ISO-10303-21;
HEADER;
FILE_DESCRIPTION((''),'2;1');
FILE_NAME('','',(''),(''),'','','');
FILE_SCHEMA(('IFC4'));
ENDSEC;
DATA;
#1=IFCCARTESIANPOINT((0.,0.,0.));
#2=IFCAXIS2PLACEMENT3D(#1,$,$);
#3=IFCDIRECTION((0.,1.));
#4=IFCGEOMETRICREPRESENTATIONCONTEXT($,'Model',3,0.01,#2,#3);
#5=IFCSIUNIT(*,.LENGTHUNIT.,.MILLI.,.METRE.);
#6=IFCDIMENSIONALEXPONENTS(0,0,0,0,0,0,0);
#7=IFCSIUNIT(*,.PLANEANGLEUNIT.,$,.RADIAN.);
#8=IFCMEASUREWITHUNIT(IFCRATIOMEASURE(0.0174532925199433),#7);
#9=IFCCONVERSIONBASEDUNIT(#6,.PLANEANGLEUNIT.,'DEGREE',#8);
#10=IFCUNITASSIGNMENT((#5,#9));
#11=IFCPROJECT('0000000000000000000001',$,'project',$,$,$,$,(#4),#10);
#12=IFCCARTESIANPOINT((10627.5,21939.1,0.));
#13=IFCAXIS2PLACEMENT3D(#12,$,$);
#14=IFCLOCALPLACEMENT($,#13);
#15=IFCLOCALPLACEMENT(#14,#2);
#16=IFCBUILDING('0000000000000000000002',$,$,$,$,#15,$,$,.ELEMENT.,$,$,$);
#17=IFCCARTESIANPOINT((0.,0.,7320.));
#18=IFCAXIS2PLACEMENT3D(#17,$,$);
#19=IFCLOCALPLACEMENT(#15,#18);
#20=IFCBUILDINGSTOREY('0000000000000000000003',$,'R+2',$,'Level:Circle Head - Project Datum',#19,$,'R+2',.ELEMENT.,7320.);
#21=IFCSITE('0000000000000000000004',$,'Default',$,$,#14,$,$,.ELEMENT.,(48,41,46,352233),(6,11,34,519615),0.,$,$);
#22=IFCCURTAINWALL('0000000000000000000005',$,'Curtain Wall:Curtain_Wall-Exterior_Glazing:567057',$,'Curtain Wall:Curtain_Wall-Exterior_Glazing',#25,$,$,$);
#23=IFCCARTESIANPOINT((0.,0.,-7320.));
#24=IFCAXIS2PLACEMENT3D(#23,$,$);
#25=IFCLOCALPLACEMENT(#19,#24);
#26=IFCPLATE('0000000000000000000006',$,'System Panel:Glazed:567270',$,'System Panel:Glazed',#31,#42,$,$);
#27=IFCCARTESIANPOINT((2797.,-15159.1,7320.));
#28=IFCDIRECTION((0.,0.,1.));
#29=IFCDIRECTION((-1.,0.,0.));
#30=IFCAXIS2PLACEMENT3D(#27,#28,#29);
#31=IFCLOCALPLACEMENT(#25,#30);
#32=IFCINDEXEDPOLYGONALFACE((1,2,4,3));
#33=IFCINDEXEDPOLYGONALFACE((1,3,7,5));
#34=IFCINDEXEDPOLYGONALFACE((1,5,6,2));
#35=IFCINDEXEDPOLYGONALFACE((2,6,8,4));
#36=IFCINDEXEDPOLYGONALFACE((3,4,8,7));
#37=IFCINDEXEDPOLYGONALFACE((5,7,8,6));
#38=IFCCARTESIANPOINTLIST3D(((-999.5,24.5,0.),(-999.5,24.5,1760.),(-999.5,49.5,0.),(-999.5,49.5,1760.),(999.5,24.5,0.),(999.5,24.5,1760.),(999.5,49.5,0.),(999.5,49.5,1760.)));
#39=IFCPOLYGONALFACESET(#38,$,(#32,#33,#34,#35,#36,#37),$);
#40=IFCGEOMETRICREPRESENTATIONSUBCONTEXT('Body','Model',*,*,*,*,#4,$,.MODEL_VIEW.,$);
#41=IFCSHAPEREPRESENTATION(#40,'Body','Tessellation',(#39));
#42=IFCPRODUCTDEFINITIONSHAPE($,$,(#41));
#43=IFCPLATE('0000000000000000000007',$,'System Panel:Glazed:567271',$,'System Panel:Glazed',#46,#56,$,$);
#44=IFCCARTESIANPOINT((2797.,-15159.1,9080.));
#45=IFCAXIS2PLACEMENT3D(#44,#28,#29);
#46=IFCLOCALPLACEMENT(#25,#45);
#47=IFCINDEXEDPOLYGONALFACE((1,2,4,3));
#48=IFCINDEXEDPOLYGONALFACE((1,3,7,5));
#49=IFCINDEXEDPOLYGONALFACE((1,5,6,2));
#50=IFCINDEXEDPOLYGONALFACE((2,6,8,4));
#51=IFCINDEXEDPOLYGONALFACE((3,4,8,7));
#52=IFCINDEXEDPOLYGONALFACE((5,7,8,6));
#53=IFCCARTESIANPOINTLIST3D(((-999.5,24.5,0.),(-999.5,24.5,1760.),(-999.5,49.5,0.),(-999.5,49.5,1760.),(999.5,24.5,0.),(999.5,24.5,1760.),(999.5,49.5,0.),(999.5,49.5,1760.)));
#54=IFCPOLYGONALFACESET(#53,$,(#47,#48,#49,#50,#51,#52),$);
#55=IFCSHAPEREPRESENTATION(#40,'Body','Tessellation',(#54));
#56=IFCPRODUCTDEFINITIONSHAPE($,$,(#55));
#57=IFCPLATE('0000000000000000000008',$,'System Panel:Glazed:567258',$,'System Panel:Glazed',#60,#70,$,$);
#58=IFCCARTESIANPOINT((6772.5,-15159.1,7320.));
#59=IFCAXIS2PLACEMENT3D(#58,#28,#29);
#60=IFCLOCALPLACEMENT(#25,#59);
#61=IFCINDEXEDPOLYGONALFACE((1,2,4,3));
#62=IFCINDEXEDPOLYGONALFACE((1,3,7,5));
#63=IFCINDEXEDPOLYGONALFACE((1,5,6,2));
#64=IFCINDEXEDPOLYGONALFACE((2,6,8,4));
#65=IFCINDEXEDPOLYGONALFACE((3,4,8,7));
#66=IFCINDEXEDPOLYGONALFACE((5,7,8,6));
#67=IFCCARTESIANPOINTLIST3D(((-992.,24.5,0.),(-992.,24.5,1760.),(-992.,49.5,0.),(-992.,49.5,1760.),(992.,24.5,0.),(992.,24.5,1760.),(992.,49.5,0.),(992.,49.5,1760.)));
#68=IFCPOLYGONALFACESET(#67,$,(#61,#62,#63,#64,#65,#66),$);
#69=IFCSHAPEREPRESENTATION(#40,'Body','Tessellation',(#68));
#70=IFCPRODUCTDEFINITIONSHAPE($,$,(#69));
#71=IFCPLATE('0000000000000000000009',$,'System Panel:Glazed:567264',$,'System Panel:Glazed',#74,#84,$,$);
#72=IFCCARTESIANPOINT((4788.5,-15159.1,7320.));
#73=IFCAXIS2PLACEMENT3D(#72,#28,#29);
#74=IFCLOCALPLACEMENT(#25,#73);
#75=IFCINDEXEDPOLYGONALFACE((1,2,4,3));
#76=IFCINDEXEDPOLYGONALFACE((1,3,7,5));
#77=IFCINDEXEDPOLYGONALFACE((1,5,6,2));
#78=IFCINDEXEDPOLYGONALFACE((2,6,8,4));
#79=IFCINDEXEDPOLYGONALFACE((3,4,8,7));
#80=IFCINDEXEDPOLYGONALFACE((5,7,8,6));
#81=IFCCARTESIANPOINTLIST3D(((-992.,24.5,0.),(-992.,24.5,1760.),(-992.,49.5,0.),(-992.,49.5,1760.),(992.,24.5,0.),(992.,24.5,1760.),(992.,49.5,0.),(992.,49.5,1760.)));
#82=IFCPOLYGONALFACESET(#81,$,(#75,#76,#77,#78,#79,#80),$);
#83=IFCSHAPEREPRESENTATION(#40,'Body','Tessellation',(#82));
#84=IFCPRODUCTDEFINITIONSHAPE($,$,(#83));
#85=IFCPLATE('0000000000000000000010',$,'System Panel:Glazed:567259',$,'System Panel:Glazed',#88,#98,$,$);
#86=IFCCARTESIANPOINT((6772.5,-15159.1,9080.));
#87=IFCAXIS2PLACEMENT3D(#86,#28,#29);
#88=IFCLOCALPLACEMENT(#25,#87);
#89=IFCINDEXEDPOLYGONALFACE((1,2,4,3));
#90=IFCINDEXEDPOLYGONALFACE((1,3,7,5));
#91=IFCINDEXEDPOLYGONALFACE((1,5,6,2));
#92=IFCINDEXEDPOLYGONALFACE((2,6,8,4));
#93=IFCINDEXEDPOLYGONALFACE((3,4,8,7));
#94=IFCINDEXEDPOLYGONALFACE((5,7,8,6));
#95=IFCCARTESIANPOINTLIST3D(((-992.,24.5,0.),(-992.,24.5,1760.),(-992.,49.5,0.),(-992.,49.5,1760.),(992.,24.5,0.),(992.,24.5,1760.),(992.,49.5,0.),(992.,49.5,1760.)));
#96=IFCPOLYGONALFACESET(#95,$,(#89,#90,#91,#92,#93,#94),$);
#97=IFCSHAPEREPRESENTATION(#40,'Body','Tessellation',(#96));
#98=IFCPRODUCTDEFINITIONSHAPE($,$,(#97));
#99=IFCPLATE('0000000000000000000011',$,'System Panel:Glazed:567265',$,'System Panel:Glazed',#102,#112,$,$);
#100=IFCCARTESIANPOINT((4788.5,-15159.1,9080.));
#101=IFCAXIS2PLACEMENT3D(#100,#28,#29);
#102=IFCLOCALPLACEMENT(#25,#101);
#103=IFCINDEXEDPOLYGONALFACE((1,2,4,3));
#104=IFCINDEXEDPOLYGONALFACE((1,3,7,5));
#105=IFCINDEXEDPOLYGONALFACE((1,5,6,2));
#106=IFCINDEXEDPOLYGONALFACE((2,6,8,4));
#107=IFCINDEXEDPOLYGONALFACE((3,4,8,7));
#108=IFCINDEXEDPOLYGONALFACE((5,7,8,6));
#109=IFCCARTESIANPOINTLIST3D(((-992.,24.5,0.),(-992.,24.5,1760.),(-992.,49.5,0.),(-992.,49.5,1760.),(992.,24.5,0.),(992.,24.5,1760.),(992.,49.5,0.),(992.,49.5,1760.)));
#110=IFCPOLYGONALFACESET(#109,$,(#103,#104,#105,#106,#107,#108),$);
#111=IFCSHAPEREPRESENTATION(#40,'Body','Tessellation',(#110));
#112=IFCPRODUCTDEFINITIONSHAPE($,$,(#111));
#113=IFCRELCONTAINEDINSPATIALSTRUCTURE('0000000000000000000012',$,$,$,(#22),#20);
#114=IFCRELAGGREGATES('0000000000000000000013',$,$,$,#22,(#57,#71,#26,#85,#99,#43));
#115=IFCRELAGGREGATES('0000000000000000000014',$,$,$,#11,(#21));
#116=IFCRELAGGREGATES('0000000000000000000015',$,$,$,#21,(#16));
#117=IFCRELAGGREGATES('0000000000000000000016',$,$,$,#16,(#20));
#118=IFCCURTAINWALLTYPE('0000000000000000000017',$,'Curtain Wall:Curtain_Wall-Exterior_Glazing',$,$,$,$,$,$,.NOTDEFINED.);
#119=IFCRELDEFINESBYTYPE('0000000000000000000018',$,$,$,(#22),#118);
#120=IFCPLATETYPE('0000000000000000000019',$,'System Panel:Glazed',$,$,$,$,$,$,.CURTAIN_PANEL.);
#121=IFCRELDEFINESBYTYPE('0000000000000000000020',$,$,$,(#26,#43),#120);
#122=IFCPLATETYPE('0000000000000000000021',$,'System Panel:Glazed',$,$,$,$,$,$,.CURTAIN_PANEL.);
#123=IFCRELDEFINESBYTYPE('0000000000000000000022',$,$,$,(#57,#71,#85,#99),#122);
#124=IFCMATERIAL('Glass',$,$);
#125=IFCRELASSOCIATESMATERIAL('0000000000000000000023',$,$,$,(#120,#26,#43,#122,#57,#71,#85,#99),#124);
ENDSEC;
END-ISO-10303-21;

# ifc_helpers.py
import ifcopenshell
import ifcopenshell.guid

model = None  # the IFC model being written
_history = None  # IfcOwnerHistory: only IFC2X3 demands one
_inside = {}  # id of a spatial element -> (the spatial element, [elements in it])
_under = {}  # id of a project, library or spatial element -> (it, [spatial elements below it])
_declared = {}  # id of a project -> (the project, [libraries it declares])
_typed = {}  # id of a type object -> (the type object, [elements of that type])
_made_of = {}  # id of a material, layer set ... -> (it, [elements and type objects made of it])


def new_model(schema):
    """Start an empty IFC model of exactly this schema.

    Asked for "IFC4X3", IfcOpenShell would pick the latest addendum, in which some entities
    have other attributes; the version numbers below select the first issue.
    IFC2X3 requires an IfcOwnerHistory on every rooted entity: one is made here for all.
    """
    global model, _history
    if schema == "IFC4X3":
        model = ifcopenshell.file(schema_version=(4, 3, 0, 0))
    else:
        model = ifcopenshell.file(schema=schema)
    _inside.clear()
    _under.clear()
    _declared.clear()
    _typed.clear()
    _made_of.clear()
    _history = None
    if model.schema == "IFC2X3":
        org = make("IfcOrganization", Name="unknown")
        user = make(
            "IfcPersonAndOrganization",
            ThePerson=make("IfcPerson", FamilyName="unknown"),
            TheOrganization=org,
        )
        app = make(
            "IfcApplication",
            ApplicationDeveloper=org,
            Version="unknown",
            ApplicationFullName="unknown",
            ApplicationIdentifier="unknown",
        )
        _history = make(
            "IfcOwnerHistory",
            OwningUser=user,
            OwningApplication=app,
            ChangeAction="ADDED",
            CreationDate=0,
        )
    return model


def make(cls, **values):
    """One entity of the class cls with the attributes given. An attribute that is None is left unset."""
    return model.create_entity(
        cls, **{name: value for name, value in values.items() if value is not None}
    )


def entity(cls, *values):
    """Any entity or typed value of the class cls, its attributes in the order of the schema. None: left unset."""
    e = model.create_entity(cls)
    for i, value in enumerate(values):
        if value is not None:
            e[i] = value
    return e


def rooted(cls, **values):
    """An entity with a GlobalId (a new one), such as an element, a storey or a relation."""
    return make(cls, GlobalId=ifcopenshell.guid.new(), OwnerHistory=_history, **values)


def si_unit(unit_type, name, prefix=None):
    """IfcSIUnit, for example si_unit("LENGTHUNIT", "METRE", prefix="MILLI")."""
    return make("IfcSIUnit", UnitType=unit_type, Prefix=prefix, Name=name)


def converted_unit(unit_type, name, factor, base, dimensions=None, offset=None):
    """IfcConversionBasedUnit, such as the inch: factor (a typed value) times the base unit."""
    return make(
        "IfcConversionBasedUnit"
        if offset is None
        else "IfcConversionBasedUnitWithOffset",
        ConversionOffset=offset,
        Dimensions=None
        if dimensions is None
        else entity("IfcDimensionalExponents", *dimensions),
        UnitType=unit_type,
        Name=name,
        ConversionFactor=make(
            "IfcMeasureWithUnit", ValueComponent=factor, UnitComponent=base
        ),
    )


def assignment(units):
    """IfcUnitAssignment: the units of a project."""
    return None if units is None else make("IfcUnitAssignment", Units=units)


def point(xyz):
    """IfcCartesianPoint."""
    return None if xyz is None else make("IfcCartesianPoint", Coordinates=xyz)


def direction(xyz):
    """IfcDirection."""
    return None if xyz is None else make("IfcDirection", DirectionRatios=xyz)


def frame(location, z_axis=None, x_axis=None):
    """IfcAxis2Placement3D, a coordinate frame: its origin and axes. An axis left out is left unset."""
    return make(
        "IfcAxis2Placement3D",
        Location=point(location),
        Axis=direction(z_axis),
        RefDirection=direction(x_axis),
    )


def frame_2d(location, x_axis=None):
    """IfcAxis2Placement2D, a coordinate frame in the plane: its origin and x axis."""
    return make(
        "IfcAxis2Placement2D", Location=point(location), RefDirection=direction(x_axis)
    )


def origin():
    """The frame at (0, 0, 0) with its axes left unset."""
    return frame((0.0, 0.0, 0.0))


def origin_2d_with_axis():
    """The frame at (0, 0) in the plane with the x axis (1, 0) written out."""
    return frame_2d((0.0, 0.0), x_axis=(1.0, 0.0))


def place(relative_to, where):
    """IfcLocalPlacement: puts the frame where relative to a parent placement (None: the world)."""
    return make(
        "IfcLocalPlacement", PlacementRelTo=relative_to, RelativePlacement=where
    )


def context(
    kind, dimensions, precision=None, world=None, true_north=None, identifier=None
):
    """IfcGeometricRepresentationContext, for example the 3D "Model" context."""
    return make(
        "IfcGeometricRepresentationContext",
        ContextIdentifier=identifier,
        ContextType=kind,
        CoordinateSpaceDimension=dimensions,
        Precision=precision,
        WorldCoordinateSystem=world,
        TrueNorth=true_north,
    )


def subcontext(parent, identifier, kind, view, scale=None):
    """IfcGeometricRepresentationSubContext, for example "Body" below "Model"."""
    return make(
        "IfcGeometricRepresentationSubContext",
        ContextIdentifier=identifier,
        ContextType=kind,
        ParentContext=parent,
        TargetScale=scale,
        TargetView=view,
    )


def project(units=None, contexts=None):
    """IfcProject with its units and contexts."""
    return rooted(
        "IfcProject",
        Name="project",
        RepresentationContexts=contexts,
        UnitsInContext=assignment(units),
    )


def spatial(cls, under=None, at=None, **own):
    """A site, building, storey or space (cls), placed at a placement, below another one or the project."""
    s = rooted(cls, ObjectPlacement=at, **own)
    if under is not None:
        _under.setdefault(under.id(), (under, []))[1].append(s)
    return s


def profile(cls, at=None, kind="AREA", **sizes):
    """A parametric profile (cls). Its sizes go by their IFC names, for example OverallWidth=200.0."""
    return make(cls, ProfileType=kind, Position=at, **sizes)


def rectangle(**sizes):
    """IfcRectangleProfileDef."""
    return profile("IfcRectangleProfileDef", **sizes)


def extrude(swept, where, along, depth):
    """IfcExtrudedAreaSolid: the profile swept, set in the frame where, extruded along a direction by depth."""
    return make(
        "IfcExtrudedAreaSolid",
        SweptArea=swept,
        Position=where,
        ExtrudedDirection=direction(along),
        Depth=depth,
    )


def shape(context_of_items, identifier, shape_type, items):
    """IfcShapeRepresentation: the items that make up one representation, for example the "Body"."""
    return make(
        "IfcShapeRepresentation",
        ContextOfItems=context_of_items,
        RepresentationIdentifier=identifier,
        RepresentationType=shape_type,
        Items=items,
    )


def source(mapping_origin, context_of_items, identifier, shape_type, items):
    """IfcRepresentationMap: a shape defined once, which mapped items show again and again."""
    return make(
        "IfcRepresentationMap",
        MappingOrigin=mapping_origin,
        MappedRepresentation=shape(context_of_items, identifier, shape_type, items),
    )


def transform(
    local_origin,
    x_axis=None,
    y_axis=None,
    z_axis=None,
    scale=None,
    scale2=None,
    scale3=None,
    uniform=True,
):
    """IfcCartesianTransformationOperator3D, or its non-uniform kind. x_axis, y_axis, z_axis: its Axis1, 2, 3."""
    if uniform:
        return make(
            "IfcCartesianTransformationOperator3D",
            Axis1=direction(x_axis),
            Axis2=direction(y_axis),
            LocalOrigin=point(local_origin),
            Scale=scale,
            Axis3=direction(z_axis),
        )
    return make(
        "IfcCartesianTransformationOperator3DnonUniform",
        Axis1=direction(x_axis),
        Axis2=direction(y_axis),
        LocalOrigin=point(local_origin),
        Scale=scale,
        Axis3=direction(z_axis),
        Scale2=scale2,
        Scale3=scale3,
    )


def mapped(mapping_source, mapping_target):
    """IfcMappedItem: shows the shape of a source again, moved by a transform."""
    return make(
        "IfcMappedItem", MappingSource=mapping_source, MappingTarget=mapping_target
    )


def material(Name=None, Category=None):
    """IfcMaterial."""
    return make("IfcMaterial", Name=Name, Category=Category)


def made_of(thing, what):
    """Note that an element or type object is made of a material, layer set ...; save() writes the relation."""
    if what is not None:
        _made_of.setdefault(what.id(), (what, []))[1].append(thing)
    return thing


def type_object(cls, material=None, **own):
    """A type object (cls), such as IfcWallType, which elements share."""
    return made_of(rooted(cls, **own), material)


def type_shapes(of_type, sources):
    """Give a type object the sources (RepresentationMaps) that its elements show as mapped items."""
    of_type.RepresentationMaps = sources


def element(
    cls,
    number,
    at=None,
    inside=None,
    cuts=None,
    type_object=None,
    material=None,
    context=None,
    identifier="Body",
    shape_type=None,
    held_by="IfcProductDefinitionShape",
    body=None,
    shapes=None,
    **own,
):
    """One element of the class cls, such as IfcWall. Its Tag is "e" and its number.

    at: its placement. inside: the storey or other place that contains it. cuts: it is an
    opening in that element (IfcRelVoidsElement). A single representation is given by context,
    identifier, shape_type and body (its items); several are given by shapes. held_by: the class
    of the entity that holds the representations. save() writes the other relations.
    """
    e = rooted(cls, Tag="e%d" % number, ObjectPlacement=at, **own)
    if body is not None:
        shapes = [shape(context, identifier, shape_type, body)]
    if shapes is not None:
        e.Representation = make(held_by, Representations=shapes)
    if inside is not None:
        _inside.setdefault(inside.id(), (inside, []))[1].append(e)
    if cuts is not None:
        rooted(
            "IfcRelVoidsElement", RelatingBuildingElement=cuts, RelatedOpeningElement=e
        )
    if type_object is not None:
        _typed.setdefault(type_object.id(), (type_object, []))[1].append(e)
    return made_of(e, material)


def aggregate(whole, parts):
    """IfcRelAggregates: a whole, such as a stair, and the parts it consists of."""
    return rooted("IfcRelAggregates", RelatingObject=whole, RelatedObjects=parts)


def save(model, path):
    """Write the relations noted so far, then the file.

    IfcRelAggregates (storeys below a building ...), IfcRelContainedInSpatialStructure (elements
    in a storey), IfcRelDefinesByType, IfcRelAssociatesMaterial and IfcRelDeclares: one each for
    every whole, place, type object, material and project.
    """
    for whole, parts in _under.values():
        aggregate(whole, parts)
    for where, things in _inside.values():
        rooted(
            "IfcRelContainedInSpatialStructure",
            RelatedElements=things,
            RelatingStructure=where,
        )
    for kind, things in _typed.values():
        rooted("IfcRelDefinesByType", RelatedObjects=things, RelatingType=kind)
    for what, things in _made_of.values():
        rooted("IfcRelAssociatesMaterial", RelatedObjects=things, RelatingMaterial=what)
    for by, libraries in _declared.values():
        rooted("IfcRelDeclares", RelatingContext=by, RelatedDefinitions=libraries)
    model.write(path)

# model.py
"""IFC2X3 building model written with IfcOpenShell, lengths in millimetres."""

from ifc_helpers import new_model, entity, si_unit, converted_unit, direction, frame, origin, origin_2d_with_axis, place, context, subcontext, project, spatial, rectangle, extrude, source, transform, mapped, material, type_object, type_shapes, element, aggregate, save


model = new_model("IFC2X3")

# Units and contexts
model_context = context("Model", 3, precision=0.01, world=origin(), true_north=direction((0.0, 1.0)))
body_context = subcontext(model_context, "Body", "Model", "MODEL_VIEW")
ifc_project = project(units=[si_unit("LENGTHUNIT", "METRE", prefix="MILLI"), converted_unit("PLANEANGLEUNIT", "DEGREE", entity("IfcRatioMeasure", 0.0174532925199433), si_unit("PLANEANGLEUNIT", "RADIAN"), dimensions=[0, 0, 0, 0, 0, 0, 0])], contexts=[model_context])

# Site, building, storey
site_placement = place(None, frame((10627.5, 21939.1, 0.0)))
site = spatial("IfcSite", under=ifc_project, at=site_placement, Name="Default", CompositionType="ELEMENT", RefLatitude=(48, 41, 46, 352233), RefLongitude=(6, 11, 34, 519615), RefElevation=0.0)
building_placement = place(site_placement, origin())
building = spatial("IfcBuilding", under=site, at=building_placement, CompositionType="ELEMENT")
storey_placement = place(building_placement, frame((0.0, 0.0, 7320.0)))
storey = spatial("IfcBuildingStorey", under=building, at=storey_placement, Name="R+2", ObjectType="Level:Circle Head - Project Datum", LongName="R+2", CompositionType="ELEMENT", Elevation=7320.0)

# Curtain wall, plates
curtain_wall_type = type_object("IfcCurtainWallType", Name="Curtain Wall:Curtain_Wall-Exterior_Glazing", PredefinedType="NOTDEFINED")
curtain_wall_placement = place(storey_placement, frame((0.0, 0.0, -7320.0)))
curtain_wall = element("IfcCurtainWall", 1, at=curtain_wall_placement, inside=storey, type_object=curtain_wall_type, Name="Curtain Wall:Curtain_Wall-Exterior_Glazing:567057", ObjectType="Curtain Wall:Curtain_Wall-Exterior_Glazing")
ifc_material_1 = material(Name="Glass")
plate_type_1 = type_object("IfcPlateType", Name="System Panel:Glazed", PredefinedType="CURTAIN_PANEL", material=ifc_material_1)
shared_shape_1 = source(origin(), body_context, "Body", "SweptSolid", [
    extrude(rectangle(XDim=25.0, YDim=1999.0, at=origin_2d_with_axis()), frame((0.0, 37.0, 0.0), z_axis=(0.0, 0.0, 1.0), x_axis=(0.0, 1.0, 0.0)), (0.0, 0.0, 1.0), 1760.0),
])
type_shapes(plate_type_1, [shared_shape_1])
plate_1_placement = place(curtain_wall_placement, frame((2797.0, -15159.1, 7320.0), z_axis=(0.0, 0.0, 1.0), x_axis=(-1.0, 0.0, 0.0)))
plate_1 = element("IfcPlate", 2, at=plate_1_placement, type_object=plate_type_1, material=ifc_material_1, Name="System Panel:Glazed:567270", ObjectType="System Panel:Glazed", context=body_context, shape_type="MappedRepresentation", body=[
    mapped(shared_shape_1, transform((0.0, 0.0, 0.0), scale=1.0)),
])
plate_2_placement = place(curtain_wall_placement, frame((2797.0, -15159.1, 9080.0), z_axis=(0.0, 0.0, 1.0), x_axis=(-1.0, 0.0, 0.0)))
plate_2 = element("IfcPlate", 3, at=plate_2_placement, type_object=plate_type_1, material=ifc_material_1, Name="System Panel:Glazed:567271", ObjectType="System Panel:Glazed", context=body_context, shape_type="MappedRepresentation", body=[
    mapped(shared_shape_1, transform((0.0, 0.0, 0.0), scale=1.0)),
])
plate_type_2 = type_object("IfcPlateType", Name="System Panel:Glazed", PredefinedType="CURTAIN_PANEL", material=ifc_material_1)
shared_shape_2 = source(origin(), body_context, "Body", "SweptSolid", [
    extrude(rectangle(XDim=25.0, YDim=1984.0, at=origin_2d_with_axis()), frame((0.0, 37.0, 0.0), z_axis=(0.0, 0.0, 1.0), x_axis=(0.0, 1.0, 0.0)), (0.0, 0.0, 1.0), 1760.0),
])
type_shapes(plate_type_2, [shared_shape_2])
plate_3_placement = place(curtain_wall_placement, frame((6772.5, -15159.1, 7320.0), z_axis=(0.0, 0.0, 1.0), x_axis=(-1.0, 0.0, 0.0)))
plate_3 = element("IfcPlate", 4, at=plate_3_placement, type_object=plate_type_2, material=ifc_material_1, Name="System Panel:Glazed:567258", ObjectType="System Panel:Glazed", context=body_context, shape_type="MappedRepresentation", body=[
    mapped(shared_shape_2, transform((0.0, 0.0, 0.0), scale=1.0)),
])
plate_4_placement = place(curtain_wall_placement, frame((4788.5, -15159.1, 7320.0), z_axis=(0.0, 0.0, 1.0), x_axis=(-1.0, 0.0, 0.0)))
plate_4 = element("IfcPlate", 5, at=plate_4_placement, type_object=plate_type_2, material=ifc_material_1, Name="System Panel:Glazed:567264", ObjectType="System Panel:Glazed", context=body_context, shape_type="MappedRepresentation", body=[
    mapped(shared_shape_2, transform((0.0, 0.0, 0.0), scale=1.0)),
])
plate_5_placement = place(curtain_wall_placement, frame((6772.5, -15159.1, 9080.0), z_axis=(0.0, 0.0, 1.0), x_axis=(-1.0, 0.0, 0.0)))
plate_5 = element("IfcPlate", 6, at=plate_5_placement, type_object=plate_type_2, material=ifc_material_1, Name="System Panel:Glazed:567259", ObjectType="System Panel:Glazed", context=body_context, shape_type="MappedRepresentation", body=[
    mapped(shared_shape_2, transform((0.0, 0.0, 0.0), scale=1.0)),
])
plate_6_placement = place(curtain_wall_placement, frame((4788.5, -15159.1, 9080.0), z_axis=(0.0, 0.0, 1.0), x_axis=(-1.0, 0.0, 0.0)))
plate_6 = element("IfcPlate", 7, at=plate_6_placement, type_object=plate_type_2, material=ifc_material_1, Name="System Panel:Glazed:567265", ObjectType="System Panel:Glazed", context=body_context, shape_type="MappedRepresentation", body=[
    mapped(shared_shape_2, transform((0.0, 0.0, 0.0), scale=1.0)),
])
aggregate(curtain_wall, [plate_3, plate_4, plate_1, plate_5, plate_6, plate_2])

save(model, "model.ifc")
